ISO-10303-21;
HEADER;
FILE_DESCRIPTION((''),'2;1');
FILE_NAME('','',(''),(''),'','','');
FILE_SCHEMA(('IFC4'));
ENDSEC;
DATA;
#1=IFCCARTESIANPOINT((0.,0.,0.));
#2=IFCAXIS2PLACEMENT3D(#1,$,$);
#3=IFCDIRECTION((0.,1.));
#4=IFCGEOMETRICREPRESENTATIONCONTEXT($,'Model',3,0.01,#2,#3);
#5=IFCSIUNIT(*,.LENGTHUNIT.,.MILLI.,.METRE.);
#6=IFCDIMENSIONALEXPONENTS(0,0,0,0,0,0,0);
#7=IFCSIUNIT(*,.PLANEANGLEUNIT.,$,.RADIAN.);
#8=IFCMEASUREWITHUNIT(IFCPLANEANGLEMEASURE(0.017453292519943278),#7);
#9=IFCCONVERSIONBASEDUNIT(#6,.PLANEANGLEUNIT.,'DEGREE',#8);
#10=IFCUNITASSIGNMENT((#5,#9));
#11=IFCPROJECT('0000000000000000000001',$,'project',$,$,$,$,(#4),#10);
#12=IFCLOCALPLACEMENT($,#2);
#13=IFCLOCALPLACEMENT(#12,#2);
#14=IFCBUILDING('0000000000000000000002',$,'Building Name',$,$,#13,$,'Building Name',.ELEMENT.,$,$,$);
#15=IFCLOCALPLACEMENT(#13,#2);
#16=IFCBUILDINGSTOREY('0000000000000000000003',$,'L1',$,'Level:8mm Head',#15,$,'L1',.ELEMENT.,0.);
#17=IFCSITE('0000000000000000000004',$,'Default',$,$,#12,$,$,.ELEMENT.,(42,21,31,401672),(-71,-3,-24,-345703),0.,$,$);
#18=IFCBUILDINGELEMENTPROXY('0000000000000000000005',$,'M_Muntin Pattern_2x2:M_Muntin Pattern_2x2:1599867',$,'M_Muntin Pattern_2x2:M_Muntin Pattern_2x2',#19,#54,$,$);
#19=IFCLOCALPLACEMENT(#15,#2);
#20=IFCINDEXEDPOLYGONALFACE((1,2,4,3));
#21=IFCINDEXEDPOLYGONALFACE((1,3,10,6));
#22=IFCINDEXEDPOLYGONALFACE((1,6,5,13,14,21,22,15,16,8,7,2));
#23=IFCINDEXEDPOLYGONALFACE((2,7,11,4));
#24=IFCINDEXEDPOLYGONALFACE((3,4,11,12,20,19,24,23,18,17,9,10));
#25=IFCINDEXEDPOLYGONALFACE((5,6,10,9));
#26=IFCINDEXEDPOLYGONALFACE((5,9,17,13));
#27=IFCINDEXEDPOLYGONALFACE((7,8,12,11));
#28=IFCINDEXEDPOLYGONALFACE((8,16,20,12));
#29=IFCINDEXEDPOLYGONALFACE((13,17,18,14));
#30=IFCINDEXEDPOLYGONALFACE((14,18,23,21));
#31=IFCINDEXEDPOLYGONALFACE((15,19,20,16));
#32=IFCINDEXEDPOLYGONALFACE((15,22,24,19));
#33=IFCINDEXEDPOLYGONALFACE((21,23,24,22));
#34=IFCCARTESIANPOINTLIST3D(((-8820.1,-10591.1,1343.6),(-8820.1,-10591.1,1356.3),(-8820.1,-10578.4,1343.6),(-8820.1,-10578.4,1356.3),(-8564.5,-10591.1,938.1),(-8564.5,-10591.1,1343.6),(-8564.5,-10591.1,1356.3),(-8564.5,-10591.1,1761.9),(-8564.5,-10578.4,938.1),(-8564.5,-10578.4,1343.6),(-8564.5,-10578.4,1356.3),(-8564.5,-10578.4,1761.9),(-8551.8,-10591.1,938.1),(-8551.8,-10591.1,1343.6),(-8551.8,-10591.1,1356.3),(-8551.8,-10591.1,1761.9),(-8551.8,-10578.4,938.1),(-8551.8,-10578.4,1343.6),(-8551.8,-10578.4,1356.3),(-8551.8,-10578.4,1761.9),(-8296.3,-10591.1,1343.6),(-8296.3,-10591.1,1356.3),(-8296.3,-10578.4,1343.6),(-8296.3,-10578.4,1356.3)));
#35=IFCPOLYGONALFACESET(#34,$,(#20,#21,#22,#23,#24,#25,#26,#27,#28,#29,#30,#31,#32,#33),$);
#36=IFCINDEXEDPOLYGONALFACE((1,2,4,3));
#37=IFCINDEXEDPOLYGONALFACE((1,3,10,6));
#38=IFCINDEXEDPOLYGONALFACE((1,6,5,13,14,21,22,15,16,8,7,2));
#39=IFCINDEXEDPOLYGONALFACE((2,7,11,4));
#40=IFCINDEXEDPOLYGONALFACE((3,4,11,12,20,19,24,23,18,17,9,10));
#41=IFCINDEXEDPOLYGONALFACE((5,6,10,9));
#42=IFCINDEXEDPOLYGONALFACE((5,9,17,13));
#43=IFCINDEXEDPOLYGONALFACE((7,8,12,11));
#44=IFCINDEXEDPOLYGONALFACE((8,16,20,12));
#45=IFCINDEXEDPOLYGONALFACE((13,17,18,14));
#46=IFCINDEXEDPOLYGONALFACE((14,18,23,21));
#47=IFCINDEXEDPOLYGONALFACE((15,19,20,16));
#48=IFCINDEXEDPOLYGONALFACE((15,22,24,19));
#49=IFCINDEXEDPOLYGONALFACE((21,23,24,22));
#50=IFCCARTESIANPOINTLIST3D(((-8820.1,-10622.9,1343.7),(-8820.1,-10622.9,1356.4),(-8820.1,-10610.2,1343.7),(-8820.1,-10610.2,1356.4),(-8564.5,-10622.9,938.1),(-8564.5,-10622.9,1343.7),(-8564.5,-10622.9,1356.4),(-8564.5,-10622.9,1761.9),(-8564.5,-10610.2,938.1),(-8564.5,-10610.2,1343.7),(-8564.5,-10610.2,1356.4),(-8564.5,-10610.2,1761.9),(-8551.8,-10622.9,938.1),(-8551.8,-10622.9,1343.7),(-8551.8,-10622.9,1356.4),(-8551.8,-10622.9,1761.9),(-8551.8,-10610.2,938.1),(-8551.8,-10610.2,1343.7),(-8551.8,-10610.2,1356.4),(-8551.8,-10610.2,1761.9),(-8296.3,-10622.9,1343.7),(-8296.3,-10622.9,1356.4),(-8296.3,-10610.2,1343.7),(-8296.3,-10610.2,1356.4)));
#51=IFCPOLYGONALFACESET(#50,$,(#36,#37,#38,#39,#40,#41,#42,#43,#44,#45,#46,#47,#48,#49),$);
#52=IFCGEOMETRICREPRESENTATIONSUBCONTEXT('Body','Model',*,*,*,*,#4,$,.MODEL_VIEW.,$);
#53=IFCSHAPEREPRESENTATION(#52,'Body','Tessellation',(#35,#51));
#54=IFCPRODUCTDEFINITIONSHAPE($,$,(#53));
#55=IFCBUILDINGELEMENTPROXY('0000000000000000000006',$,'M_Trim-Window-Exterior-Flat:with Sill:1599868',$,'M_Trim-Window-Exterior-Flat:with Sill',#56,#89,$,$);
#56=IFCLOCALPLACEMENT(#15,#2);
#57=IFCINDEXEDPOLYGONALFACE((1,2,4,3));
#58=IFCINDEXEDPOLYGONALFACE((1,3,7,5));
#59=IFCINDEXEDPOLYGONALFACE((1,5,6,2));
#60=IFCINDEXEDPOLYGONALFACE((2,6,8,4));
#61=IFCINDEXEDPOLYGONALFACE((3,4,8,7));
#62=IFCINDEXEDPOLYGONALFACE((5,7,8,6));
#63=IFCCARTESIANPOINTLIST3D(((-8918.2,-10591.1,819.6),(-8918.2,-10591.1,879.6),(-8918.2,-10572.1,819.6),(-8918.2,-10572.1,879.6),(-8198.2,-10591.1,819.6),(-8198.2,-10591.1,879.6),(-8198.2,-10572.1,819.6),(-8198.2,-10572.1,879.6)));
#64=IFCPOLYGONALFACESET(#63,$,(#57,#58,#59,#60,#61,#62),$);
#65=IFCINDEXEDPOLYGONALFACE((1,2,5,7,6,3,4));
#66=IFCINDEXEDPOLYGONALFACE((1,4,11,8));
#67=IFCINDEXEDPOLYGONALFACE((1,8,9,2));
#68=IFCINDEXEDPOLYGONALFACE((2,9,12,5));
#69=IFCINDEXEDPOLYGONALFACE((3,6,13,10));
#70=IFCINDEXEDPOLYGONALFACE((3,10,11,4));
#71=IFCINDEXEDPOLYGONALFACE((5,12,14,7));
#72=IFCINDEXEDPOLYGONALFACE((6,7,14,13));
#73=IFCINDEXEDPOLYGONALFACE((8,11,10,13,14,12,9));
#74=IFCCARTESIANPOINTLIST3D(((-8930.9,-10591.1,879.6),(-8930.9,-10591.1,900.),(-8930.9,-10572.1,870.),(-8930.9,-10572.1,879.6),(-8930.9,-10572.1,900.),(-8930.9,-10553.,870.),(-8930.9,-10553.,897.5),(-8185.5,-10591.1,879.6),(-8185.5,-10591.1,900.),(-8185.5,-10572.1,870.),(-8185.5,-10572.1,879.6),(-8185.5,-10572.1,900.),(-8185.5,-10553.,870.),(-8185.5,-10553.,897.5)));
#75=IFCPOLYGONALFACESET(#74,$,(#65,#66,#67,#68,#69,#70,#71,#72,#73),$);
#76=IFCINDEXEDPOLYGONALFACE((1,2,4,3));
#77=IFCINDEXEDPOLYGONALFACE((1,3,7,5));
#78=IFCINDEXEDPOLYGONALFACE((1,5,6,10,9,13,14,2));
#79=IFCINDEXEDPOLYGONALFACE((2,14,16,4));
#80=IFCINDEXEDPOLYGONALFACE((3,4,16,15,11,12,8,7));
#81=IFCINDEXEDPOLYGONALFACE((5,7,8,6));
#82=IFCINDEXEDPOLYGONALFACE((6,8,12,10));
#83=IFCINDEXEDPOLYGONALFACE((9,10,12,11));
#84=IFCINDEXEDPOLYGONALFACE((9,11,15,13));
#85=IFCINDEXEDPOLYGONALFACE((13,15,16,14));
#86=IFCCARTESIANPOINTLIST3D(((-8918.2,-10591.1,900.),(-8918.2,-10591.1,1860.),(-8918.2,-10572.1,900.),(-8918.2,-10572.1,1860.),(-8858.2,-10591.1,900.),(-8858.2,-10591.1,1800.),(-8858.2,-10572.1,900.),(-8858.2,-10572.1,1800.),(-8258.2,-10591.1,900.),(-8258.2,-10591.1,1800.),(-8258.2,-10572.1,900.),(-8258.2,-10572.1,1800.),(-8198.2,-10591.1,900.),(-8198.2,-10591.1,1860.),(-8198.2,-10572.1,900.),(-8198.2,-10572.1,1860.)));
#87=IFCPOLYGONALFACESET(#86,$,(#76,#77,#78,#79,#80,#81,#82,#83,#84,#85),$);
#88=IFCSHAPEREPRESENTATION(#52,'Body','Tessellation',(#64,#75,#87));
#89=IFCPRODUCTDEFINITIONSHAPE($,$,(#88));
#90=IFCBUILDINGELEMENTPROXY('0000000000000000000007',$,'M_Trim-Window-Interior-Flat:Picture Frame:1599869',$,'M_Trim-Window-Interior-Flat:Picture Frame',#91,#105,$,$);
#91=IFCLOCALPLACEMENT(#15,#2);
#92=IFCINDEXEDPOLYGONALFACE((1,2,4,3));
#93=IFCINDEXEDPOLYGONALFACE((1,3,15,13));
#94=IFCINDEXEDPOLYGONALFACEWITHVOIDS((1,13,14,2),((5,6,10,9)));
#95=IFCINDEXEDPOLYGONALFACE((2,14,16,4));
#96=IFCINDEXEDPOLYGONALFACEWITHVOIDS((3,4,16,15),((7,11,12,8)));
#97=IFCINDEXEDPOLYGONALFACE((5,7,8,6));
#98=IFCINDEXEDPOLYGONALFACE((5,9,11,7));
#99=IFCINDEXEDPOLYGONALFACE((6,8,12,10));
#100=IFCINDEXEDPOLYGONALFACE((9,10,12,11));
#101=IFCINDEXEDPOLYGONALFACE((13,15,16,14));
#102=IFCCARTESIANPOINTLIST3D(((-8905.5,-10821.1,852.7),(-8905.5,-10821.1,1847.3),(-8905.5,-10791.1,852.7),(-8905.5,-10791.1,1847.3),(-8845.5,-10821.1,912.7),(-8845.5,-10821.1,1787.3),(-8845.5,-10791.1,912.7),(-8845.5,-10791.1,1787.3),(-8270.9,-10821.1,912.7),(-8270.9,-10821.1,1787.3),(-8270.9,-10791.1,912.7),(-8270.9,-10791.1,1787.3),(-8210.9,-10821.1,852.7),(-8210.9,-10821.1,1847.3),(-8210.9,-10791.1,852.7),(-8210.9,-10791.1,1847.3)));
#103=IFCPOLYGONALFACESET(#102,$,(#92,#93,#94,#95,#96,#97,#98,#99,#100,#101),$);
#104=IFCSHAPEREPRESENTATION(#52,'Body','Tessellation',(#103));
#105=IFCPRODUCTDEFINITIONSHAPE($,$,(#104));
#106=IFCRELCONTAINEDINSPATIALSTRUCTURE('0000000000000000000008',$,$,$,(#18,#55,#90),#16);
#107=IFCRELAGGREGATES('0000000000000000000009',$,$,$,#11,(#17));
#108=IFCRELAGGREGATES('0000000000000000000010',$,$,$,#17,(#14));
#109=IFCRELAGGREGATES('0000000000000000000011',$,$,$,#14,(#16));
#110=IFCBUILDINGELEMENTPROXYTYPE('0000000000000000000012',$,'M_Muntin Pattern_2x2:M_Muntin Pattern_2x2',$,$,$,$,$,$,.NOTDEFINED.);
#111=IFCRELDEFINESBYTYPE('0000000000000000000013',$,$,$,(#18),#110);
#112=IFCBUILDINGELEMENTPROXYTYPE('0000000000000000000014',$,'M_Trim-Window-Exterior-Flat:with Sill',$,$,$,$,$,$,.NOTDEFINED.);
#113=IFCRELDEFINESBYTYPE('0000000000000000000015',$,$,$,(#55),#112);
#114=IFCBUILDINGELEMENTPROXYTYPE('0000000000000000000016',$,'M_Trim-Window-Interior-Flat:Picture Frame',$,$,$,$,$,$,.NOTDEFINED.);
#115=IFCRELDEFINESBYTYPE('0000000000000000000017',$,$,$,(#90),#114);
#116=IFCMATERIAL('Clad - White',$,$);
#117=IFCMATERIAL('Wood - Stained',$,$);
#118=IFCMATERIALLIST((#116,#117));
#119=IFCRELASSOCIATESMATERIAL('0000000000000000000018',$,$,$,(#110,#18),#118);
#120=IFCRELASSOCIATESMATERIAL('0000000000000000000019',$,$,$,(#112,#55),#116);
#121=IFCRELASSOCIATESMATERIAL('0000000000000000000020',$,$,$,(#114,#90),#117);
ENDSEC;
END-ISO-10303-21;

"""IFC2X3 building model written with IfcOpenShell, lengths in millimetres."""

from ifc_helpers import new_model, entity, si_unit, converted_unit, direction, frame, frame_2d, origin, place, context, subcontext, project, spatial, polyline, rectangle, outline, extrude, source, transform, mapped, material, material_list, type_object, type_shapes, element, save


model = new_model("IFC2X3")

# Units and contexts
model_context = context("Model", 3, precision=0.01, world=origin(), true_north=direction((0.0, 1.0)))
body_context = subcontext(model_context, "Body", "Model", "MODEL_VIEW")
ifc_project = project(units=[si_unit("LENGTHUNIT", "METRE", prefix="MILLI"), converted_unit("PLANEANGLEUNIT", "DEGREE", entity("IfcPlaneAngleMeasure", 0.017453292519943278), si_unit("PLANEANGLEUNIT", "RADIAN"), dimensions=[0, 0, 0, 0, 0, 0, 0])], contexts=[model_context])

# Site, building, storey
site_placement = place(None, origin())
site = spatial("IfcSite", under=ifc_project, at=site_placement, Name="Default", CompositionType="ELEMENT", RefLatitude=(42, 21, 31, 401672), RefLongitude=(-71, -3, -24, -345703), RefElevation=0.0)
building_placement = place(site_placement, origin())
building = spatial("IfcBuilding", under=site, at=building_placement, Name="Building Name", LongName="Building Name", CompositionType="ELEMENT")
storey_placement = place(building_placement, origin())
storey = spatial("IfcBuildingStorey", under=building, at=storey_placement, Name="L1", ObjectType="Level:8mm Head", LongName="L1", CompositionType="ELEMENT", Elevation=0.0)

# Building element proxies
ifc_material_1 = material(Name="Clad - White")
ifc_material_2 = material(Name="Wood - Stained")
ifc_material_list = material_list([ifc_material_1, ifc_material_2])
building_element_proxy_type_1 = type_object("IfcBuildingElementProxyType", Name="M_Muntin Pattern_2x2:M_Muntin Pattern_2x2", PredefinedType="NOTDEFINED", material=ifc_material_list)
shared_shape_1 = source(origin(), body_context, "Body", "SweptSolid", [
    extrude(outline(polyline([(6.4, -6.4), (411.9, -6.4), (411.9, 6.3), (6.4, 6.3), (6.4, 261.9), (-6.3, 261.9), (-6.3, 6.3), (-411.9, 6.3), (-411.9, -6.4), (-6.3, -6.4), (-6.3, -261.9), (6.4, -261.9), (6.4, -6.4)])), frame((0.0, -22.2, 411.9), z_axis=(0.0, 1.0, 0.0), x_axis=(0.0, 0.0, 1.0)), (0.0, 0.0, 1.0), 12.7),
    extrude(outline(polyline([(6.4, -6.4), (411.9, -6.4), (411.9, 6.3), (6.4, 6.3), (6.4, 261.9), (-6.3, 261.9), (-6.3, 6.3), (-411.9, 6.3), (-411.9, -6.4), (-6.3, -6.4), (-6.3, -261.9), (6.4, -261.9), (6.4, -6.4)])), frame((0.0, 9.5, 411.9), z_axis=(0.0, 1.0, 0.0), x_axis=(0.0, 0.0, 1.0)), (0.0, 0.0, 1.0), 12.7),
])
type_shapes(building_element_proxy_type_1, [shared_shape_1])
proxy_1_placement = place(storey_placement, frame((-8558.2, -10600.6, 938.1), z_axis=(0.0, 0.0, 1.0), x_axis=(-1.0, 0.0, 0.0)))
element("IfcBuildingElementProxy", 1, at=proxy_1_placement, inside=storey, type_object=building_element_proxy_type_1, material=ifc_material_list, Name="M_Muntin Pattern_2x2:M_Muntin Pattern_2x2:1599867", ObjectType="M_Muntin Pattern_2x2:M_Muntin Pattern_2x2", context=body_context, shape_type="MappedRepresentation", body=[
    mapped(shared_shape_1, transform((0.0, 0.0, 0.0), scale=1.0)),
])
building_element_proxy_type_2 = type_object("IfcBuildingElementProxyType", Name="M_Trim-Window-Exterior-Flat:with Sill", PredefinedType="NOTDEFINED", material=ifc_material_1)
shared_shape_2 = source(origin(), body_context, "Body", "SweptSolid", [
    extrude(rectangle(XDim=720.0, YDim=60.0, at=frame_2d((0.0, 0.0), x_axis=(1.0, 0.0))), frame((0.0, -950.4, 0.0), z_axis=(0.0, 0.0, 1.0), x_axis=(-1.0, 0.0, 0.0)), (0.0, 0.0, 1.0), 19.0),
    extrude(outline(polyline([(-19.0, -15.2), (0.0, -15.2), (0.0, -5.7), (19.0, -5.7), (19.0, 14.8), (0.0, 14.8), (-19.0, 12.3), (-19.0, -15.2)])), frame((-372.7, -914.8, 19.0), z_axis=(1.0, 0.0, 0.0), x_axis=(0.0, 0.0, -1.0)), (0.0, 0.0, 1.0), 745.4),
    extrude(outline(polyline([(-495.0, -360.0), (465.0, -360.0), (465.0, -300.0), (-435.0, -300.0), (-435.0, 300.0), (465.0, 300.0), (465.0, 360.0), (-495.0, 360.0), (-495.0, -360.0)])), frame((0.0, -435.0, 0.0), z_axis=(0.0, 0.0, 1.0), x_axis=(0.0, -1.0, 0.0)), (0.0, 0.0, 1.0), 19.0),
])
type_shapes(building_element_proxy_type_2, [shared_shape_2])
proxy_2_placement = place(storey_placement, frame((-8558.2, -10591.1, 1800.0), z_axis=(0.0, 1.0, 0.0), x_axis=(-1.0, 0.0, 0.0)))
element("IfcBuildingElementProxy", 2, at=proxy_2_placement, inside=storey, type_object=building_element_proxy_type_2, material=ifc_material_1, Name="M_Trim-Window-Exterior-Flat:with Sill:1599868", ObjectType="M_Trim-Window-Exterior-Flat:with Sill", context=body_context, shape_type="MappedRepresentation", body=[
    mapped(shared_shape_2, transform((0.0, 0.0, 0.0), scale=1.0)),
])
building_element_proxy_type_3 = type_object("IfcBuildingElementProxyType", Name="M_Trim-Window-Interior-Flat:Picture Frame", PredefinedType="NOTDEFINED", material=ifc_material_2)
shared_shape_3 = source(origin(), body_context, "Body", "SweptSolid", [
    extrude(outline(polyline([(-347.3, -497.3), (347.3, -497.3), (347.3, 497.3), (-347.3, 497.3), (-347.3, -497.3)]), holes=[polyline([(-287.3, -437.3), (-287.3, 437.3), (287.3, 437.3), (287.3, -437.3), (-287.3, -437.3)])]), frame((0.0, -450.0, 0.0), z_axis=(0.0, 0.0, 1.0), x_axis=(-1.0, 0.0, 0.0)), (0.0, 0.0, 1.0), 30.0),
])
type_shapes(building_element_proxy_type_3, [shared_shape_3])
proxy_3_placement = place(storey_placement, frame((-8558.2, -10791.1, 1800.0), z_axis=(0.0, -1.0, 0.0), x_axis=(1.0, 0.0, 0.0)))
element("IfcBuildingElementProxy", 3, at=proxy_3_placement, inside=storey, type_object=building_element_proxy_type_3, material=ifc_material_2, Name="M_Trim-Window-Interior-Flat:Picture Frame:1599869", ObjectType="M_Trim-Window-Interior-Flat:Picture Frame", context=body_context, shape_type="MappedRepresentation", body=[
    mapped(shared_shape_3, transform((0.0, 0.0, 0.0), scale=1.0)),
])

save(model, "model.ifc")
